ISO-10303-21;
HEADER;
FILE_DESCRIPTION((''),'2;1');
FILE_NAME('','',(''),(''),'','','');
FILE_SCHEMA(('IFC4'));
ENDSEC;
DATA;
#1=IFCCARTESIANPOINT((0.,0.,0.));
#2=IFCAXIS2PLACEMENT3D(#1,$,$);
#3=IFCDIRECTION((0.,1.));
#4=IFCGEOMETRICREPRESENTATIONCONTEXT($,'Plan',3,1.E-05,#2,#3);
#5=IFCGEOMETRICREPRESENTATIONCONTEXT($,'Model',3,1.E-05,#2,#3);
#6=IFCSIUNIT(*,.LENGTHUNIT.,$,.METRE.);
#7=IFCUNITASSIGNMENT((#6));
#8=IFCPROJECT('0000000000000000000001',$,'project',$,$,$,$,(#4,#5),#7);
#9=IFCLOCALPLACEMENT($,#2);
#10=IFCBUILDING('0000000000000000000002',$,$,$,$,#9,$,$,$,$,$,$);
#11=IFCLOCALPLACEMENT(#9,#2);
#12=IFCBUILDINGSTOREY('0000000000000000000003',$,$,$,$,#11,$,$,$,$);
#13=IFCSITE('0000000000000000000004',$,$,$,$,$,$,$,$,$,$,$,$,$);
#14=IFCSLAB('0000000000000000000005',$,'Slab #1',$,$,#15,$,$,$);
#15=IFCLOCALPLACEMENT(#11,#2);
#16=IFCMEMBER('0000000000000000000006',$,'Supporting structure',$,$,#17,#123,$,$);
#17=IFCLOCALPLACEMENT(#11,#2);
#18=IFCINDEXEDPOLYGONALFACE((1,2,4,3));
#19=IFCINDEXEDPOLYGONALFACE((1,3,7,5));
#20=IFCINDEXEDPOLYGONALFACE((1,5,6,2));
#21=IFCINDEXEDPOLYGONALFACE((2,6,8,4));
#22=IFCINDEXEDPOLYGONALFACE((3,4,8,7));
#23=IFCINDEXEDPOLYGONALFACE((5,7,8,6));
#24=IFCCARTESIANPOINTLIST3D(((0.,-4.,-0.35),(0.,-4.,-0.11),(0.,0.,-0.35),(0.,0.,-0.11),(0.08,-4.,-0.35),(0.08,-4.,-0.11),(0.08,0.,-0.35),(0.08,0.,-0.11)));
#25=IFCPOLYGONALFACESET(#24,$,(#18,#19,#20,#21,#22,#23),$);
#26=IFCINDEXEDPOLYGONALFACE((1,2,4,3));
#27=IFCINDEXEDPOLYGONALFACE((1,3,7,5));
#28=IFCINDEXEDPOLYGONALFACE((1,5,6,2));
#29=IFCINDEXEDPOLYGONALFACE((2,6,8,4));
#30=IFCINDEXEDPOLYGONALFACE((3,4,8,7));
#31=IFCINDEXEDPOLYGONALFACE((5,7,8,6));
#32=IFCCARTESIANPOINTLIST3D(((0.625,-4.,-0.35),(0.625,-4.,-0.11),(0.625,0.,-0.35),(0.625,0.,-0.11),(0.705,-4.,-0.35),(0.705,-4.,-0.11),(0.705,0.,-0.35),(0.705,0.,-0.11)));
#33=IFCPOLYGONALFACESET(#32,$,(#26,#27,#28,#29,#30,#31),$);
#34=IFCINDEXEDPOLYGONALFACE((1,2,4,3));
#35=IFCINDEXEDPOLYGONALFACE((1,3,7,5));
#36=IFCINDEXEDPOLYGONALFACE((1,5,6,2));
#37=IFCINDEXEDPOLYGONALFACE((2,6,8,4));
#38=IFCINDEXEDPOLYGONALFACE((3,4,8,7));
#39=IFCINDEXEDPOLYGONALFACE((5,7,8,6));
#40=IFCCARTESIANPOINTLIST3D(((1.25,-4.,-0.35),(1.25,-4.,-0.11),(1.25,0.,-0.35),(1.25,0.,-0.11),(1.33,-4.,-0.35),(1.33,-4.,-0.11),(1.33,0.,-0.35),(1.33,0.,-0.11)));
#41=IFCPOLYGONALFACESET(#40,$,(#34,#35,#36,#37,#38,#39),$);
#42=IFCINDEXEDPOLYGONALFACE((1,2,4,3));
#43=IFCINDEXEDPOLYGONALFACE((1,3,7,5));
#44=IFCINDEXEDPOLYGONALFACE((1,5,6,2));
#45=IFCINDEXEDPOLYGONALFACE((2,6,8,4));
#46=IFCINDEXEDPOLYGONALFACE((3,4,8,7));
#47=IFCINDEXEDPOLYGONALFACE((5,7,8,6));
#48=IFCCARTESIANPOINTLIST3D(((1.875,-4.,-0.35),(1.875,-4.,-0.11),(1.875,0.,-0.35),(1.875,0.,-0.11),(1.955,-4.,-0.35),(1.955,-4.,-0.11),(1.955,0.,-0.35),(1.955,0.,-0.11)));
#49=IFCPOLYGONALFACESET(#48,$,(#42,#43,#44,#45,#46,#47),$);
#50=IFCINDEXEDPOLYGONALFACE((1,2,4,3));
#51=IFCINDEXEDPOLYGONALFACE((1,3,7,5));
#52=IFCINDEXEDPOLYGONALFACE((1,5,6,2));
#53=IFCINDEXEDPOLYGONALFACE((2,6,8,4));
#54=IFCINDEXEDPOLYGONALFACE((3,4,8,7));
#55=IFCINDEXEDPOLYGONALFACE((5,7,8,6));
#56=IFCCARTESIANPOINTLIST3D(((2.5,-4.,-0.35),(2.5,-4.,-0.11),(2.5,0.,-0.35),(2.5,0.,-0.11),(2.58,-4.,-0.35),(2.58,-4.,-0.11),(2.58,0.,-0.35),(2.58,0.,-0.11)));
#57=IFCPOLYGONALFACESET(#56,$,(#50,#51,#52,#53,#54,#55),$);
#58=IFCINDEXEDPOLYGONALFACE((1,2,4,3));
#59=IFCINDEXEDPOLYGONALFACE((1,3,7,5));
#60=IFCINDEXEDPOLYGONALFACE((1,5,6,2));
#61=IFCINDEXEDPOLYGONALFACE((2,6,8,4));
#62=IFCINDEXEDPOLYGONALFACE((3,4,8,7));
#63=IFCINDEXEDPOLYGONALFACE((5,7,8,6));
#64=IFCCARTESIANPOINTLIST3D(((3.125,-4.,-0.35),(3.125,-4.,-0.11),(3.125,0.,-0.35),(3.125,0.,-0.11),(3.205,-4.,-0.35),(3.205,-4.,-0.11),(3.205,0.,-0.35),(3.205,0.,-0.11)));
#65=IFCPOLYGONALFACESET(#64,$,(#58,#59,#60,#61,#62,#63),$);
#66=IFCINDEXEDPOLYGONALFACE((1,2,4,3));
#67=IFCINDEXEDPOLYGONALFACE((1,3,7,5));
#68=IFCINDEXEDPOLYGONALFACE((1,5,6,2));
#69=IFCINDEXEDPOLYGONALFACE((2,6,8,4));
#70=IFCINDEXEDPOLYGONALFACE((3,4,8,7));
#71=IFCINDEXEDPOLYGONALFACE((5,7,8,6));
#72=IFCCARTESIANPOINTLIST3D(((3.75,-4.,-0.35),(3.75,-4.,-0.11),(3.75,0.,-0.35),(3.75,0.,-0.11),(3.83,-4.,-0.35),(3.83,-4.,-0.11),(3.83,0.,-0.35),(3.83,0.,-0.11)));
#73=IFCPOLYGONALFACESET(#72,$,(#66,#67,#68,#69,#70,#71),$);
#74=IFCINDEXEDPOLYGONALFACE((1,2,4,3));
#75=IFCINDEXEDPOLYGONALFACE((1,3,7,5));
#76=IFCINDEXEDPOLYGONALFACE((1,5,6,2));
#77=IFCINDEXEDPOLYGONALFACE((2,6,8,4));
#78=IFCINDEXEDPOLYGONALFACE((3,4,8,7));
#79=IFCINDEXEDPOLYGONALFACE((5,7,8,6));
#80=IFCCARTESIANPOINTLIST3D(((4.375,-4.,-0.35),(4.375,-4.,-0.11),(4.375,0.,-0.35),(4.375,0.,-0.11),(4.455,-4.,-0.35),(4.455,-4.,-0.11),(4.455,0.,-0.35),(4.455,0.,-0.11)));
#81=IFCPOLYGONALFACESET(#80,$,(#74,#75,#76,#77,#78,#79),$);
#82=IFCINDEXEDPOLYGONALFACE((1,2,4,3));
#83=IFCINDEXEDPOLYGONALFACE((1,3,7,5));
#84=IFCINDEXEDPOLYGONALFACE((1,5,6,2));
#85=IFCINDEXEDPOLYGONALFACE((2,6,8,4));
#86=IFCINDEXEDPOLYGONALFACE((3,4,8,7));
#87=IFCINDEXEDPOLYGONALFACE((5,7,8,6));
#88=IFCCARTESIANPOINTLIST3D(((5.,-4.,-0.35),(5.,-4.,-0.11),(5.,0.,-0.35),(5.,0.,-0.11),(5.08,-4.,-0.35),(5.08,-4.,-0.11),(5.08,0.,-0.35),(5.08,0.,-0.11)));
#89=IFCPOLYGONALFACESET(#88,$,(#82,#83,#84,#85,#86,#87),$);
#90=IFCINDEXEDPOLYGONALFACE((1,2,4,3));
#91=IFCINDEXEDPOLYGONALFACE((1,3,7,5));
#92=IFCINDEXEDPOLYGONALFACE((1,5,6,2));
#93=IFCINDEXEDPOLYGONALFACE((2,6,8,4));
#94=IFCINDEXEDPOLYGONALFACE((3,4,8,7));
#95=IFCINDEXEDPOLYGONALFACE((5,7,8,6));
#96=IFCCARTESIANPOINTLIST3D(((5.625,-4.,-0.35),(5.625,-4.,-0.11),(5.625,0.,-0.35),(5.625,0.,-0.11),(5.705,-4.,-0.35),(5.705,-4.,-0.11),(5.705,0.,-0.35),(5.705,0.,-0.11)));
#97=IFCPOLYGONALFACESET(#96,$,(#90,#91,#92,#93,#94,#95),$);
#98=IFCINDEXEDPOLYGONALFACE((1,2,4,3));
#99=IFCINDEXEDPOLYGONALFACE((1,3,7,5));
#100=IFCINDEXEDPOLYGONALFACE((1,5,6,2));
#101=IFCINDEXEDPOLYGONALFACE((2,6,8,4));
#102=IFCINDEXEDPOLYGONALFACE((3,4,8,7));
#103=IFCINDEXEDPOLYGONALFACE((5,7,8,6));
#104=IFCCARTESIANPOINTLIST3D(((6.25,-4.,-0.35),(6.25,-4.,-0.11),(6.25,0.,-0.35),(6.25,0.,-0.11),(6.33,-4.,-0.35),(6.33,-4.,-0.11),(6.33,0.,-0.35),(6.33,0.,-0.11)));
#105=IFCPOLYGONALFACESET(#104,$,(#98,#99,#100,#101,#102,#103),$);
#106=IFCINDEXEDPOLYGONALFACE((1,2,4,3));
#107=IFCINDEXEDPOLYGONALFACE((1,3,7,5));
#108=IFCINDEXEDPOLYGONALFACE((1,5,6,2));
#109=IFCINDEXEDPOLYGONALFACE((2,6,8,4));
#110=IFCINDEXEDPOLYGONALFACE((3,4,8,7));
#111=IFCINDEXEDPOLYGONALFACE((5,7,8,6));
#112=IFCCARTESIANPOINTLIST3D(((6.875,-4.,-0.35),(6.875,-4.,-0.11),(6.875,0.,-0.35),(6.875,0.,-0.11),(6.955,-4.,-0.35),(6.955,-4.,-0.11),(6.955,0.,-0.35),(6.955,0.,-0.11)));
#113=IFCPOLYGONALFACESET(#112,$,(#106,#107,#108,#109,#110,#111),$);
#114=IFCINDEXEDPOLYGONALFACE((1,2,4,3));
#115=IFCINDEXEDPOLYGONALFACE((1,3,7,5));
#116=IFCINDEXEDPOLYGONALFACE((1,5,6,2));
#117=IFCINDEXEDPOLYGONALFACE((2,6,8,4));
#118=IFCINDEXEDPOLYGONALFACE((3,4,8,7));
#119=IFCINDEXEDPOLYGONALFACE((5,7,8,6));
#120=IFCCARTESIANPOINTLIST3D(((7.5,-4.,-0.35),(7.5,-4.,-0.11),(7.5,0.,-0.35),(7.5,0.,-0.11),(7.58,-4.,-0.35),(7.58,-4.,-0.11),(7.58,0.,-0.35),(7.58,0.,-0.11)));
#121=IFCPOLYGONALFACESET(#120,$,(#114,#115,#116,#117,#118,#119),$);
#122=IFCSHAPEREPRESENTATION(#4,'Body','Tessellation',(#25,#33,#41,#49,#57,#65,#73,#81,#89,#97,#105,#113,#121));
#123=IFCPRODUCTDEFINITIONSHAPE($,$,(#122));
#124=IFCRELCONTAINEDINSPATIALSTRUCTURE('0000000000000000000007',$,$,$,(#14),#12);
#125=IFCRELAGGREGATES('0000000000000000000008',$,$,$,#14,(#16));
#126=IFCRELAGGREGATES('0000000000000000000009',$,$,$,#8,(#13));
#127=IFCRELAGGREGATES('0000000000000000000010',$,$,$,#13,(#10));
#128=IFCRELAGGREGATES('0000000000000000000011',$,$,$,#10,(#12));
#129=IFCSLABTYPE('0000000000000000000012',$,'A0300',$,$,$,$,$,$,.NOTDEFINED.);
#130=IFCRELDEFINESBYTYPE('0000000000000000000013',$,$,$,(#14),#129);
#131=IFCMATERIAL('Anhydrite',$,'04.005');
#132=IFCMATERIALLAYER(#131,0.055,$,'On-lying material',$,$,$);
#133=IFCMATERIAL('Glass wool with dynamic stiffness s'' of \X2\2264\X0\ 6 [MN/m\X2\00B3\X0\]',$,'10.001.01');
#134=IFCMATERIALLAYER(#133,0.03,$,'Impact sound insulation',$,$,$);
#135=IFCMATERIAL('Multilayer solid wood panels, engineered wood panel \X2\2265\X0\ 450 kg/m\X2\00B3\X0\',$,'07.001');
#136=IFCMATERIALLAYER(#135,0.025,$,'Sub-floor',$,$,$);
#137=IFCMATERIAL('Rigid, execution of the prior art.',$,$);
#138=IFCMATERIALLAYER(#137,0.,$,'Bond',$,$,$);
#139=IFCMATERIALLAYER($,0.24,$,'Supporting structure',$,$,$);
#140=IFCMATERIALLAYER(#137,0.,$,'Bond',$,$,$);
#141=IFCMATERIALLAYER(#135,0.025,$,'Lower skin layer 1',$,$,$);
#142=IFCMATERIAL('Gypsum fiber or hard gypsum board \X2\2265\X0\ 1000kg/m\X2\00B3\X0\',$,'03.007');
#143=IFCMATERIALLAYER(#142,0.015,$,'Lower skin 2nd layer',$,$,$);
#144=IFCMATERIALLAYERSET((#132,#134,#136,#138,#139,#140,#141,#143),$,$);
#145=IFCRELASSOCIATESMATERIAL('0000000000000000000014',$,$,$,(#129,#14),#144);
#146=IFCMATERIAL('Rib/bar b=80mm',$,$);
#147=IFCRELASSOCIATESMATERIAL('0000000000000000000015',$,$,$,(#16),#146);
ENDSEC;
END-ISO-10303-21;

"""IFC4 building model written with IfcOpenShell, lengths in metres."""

from ifc_helpers import new_model, si_unit, direction, frame, frame_2d, origin, place, context, project, spatial, rectangle, extrude, material, layer, layer_set, type_object, element, aggregate, save


model = new_model("IFC4")

# Units and contexts
plan_context = context("Plan", 3, precision=1e-05, world=origin(), true_north=direction((0.0, 1.0)))
model_context = context("Model", 3, precision=1e-05, world=origin(), true_north=direction((0.0, 1.0)))
ifc_project = project(units=[si_unit("LENGTHUNIT", "METRE")], contexts=[plan_context, model_context])

# Site, building, storey
site = spatial("IfcSite", under=ifc_project)
building_placement = place(None, origin())
building = spatial("IfcBuilding", under=site, at=building_placement)
storey_placement = place(building_placement, origin())
storey = spatial("IfcBuildingStorey", under=building, at=storey_placement)

# Slab, member
ifc_material_1 = material(Name="Anhydrite", Category="04.005")
ifc_layer_1 = layer(ifc_material_1, 0.055, Name="On-lying material")
ifc_material_2 = material(Name="Glass wool with dynamic stiffness s' of ≤ 6 [MN/m³]", Category="10.001.01")
ifc_layer_2 = layer(ifc_material_2, 0.03, Name="Impact sound insulation")
ifc_material_3 = material(Name="Multilayer solid wood panels, engineered wood panel ≥ 450 kg/m³", Category="07.001")
ifc_layer_3 = layer(ifc_material_3, 0.025, Name="Sub-floor")
ifc_material_4 = material(Name="Rigid, execution of the prior art.")
ifc_layer_4 = layer(ifc_material_4, 0.0, Name="Bond")
ifc_layer_5 = layer(None, 0.24, Name="Supporting structure")
ifc_layer_6 = layer(ifc_material_4, 0.0, Name="Bond")
ifc_layer_7 = layer(ifc_material_3, 0.025, Name="Lower skin layer 1")
ifc_material_5 = material(Name="Gypsum fiber or hard gypsum board ≥ 1000kg/m³", Category="03.007")
ifc_layer_8 = layer(ifc_material_5, 0.015, Name="Lower skin 2nd layer")
ifc_layer_set = layer_set([ifc_layer_1, ifc_layer_2, ifc_layer_3, ifc_layer_4, ifc_layer_5, ifc_layer_6, ifc_layer_7, ifc_layer_8])
slab_type = type_object("IfcSlabType", Name="A0300", PredefinedType="NOTDEFINED", material=ifc_layer_set)
slab_placement = place(None, frame((0.0, 0.0, 0.0), z_axis=(0.0, 0.0, -1.0), x_axis=(1.0, 0.0, 0.0)))
slab = element("IfcSlab", 1, at=slab_placement, inside=storey, type_object=slab_type, material=ifc_layer_set, Name="Slab #1")
ifc_material_6 = material(Name="Rib/bar b=80mm")
member_1_placement = place(slab_placement, origin())
member_1 = element("IfcMember", 2, at=member_1_placement, material=ifc_material_6, Name="Supporting structure", context=plan_context, shape_type="SweptSolid", body=[
    extrude(rectangle(XDim=0.08, YDim=0.24, at=frame_2d((0.04, 0.12), x_axis=(1.0, 0.0))), frame((0.0, 4.0, 0.11), z_axis=(0.0, -1.0, 0.0), x_axis=(1.0, 0.0, 0.0)), (0.0, 0.0, 1.0), 4.0),
    extrude(rectangle(XDim=0.08, YDim=0.24, at=frame_2d((0.04, 0.12), x_axis=(1.0, 0.0))), frame((0.625, 4.0, 0.11), z_axis=(0.0, -1.0, 0.0), x_axis=(1.0, 0.0, 0.0)), (0.0, 0.0, 1.0), 4.0),
    extrude(rectangle(XDim=0.08, YDim=0.24, at=frame_2d((0.04, 0.12), x_axis=(1.0, 0.0))), frame((1.25, 4.0, 0.11), z_axis=(0.0, -1.0, 0.0), x_axis=(1.0, 0.0, 0.0)), (0.0, 0.0, 1.0), 4.0),
    extrude(rectangle(XDim=0.08, YDim=0.24, at=frame_2d((0.04, 0.12), x_axis=(1.0, 0.0))), frame((1.875, 4.0, 0.11), z_axis=(0.0, -1.0, 0.0), x_axis=(1.0, 0.0, 0.0)), (0.0, 0.0, 1.0), 4.0),
    extrude(rectangle(XDim=0.08, YDim=0.24, at=frame_2d((0.04, 0.12), x_axis=(1.0, 0.0))), frame((2.5, 4.0, 0.11), z_axis=(0.0, -1.0, 0.0), x_axis=(1.0, 0.0, 0.0)), (0.0, 0.0, 1.0), 4.0),
    extrude(rectangle(XDim=0.08, YDim=0.24, at=frame_2d((0.04, 0.12), x_axis=(1.0, 0.0))), frame((3.125, 4.0, 0.11), z_axis=(0.0, -1.0, 0.0), x_axis=(1.0, 0.0, 0.0)), (0.0, 0.0, 1.0), 4.0),
    extrude(rectangle(XDim=0.08, YDim=0.24, at=frame_2d((0.04, 0.12), x_axis=(1.0, 0.0))), frame((3.75, 4.0, 0.11), z_axis=(0.0, -1.0, 0.0), x_axis=(1.0, 0.0, 0.0)), (0.0, 0.0, 1.0), 4.0),
    extrude(rectangle(XDim=0.08, YDim=0.24, at=frame_2d((0.04, 0.12), x_axis=(1.0, 0.0))), frame((4.375, 4.0, 0.11), z_axis=(0.0, -1.0, 0.0), x_axis=(1.0, 0.0, 0.0)), (0.0, 0.0, 1.0), 4.0),
    extrude(rectangle(XDim=0.08, YDim=0.24, at=frame_2d((0.04, 0.12), x_axis=(1.0, 0.0))), frame((5.0, 4.0, 0.11), z_axis=(0.0, -1.0, 0.0), x_axis=(1.0, 0.0, 0.0)), (0.0, 0.0, 1.0), 4.0),
    extrude(rectangle(XDim=0.08, YDim=0.24, at=frame_2d((0.04, 0.12), x_axis=(1.0, 0.0))), frame((5.625, 4.0, 0.11), z_axis=(0.0, -1.0, 0.0), x_axis=(1.0, 0.0, 0.0)), (0.0, 0.0, 1.0), 4.0),
    extrude(rectangle(XDim=0.08, YDim=0.24, at=frame_2d((0.04, 0.12), x_axis=(1.0, 0.0))), frame((6.25, 4.0, 0.11), z_axis=(0.0, -1.0, 0.0), x_axis=(1.0, 0.0, 0.0)), (0.0, 0.0, 1.0), 4.0),
    extrude(rectangle(XDim=0.08, YDim=0.24, at=frame_2d((0.04, 0.12), x_axis=(1.0, 0.0))), frame((6.875, 4.0, 0.11), z_axis=(0.0, -1.0, 0.0), x_axis=(1.0, 0.0, 0.0)), (0.0, 0.0, 1.0), 4.0),
    extrude(rectangle(XDim=0.08, YDim=0.24, at=frame_2d((0.04, 0.12), x_axis=(1.0, 0.0))), frame((7.5, 4.0, 0.11), z_axis=(0.0, -1.0, 0.0), x_axis=(1.0, 0.0, 0.0)), (0.0, 0.0, 1.0), 4.0),
])
aggregate(slab, [member_1])

save(model, "model.ifc")
